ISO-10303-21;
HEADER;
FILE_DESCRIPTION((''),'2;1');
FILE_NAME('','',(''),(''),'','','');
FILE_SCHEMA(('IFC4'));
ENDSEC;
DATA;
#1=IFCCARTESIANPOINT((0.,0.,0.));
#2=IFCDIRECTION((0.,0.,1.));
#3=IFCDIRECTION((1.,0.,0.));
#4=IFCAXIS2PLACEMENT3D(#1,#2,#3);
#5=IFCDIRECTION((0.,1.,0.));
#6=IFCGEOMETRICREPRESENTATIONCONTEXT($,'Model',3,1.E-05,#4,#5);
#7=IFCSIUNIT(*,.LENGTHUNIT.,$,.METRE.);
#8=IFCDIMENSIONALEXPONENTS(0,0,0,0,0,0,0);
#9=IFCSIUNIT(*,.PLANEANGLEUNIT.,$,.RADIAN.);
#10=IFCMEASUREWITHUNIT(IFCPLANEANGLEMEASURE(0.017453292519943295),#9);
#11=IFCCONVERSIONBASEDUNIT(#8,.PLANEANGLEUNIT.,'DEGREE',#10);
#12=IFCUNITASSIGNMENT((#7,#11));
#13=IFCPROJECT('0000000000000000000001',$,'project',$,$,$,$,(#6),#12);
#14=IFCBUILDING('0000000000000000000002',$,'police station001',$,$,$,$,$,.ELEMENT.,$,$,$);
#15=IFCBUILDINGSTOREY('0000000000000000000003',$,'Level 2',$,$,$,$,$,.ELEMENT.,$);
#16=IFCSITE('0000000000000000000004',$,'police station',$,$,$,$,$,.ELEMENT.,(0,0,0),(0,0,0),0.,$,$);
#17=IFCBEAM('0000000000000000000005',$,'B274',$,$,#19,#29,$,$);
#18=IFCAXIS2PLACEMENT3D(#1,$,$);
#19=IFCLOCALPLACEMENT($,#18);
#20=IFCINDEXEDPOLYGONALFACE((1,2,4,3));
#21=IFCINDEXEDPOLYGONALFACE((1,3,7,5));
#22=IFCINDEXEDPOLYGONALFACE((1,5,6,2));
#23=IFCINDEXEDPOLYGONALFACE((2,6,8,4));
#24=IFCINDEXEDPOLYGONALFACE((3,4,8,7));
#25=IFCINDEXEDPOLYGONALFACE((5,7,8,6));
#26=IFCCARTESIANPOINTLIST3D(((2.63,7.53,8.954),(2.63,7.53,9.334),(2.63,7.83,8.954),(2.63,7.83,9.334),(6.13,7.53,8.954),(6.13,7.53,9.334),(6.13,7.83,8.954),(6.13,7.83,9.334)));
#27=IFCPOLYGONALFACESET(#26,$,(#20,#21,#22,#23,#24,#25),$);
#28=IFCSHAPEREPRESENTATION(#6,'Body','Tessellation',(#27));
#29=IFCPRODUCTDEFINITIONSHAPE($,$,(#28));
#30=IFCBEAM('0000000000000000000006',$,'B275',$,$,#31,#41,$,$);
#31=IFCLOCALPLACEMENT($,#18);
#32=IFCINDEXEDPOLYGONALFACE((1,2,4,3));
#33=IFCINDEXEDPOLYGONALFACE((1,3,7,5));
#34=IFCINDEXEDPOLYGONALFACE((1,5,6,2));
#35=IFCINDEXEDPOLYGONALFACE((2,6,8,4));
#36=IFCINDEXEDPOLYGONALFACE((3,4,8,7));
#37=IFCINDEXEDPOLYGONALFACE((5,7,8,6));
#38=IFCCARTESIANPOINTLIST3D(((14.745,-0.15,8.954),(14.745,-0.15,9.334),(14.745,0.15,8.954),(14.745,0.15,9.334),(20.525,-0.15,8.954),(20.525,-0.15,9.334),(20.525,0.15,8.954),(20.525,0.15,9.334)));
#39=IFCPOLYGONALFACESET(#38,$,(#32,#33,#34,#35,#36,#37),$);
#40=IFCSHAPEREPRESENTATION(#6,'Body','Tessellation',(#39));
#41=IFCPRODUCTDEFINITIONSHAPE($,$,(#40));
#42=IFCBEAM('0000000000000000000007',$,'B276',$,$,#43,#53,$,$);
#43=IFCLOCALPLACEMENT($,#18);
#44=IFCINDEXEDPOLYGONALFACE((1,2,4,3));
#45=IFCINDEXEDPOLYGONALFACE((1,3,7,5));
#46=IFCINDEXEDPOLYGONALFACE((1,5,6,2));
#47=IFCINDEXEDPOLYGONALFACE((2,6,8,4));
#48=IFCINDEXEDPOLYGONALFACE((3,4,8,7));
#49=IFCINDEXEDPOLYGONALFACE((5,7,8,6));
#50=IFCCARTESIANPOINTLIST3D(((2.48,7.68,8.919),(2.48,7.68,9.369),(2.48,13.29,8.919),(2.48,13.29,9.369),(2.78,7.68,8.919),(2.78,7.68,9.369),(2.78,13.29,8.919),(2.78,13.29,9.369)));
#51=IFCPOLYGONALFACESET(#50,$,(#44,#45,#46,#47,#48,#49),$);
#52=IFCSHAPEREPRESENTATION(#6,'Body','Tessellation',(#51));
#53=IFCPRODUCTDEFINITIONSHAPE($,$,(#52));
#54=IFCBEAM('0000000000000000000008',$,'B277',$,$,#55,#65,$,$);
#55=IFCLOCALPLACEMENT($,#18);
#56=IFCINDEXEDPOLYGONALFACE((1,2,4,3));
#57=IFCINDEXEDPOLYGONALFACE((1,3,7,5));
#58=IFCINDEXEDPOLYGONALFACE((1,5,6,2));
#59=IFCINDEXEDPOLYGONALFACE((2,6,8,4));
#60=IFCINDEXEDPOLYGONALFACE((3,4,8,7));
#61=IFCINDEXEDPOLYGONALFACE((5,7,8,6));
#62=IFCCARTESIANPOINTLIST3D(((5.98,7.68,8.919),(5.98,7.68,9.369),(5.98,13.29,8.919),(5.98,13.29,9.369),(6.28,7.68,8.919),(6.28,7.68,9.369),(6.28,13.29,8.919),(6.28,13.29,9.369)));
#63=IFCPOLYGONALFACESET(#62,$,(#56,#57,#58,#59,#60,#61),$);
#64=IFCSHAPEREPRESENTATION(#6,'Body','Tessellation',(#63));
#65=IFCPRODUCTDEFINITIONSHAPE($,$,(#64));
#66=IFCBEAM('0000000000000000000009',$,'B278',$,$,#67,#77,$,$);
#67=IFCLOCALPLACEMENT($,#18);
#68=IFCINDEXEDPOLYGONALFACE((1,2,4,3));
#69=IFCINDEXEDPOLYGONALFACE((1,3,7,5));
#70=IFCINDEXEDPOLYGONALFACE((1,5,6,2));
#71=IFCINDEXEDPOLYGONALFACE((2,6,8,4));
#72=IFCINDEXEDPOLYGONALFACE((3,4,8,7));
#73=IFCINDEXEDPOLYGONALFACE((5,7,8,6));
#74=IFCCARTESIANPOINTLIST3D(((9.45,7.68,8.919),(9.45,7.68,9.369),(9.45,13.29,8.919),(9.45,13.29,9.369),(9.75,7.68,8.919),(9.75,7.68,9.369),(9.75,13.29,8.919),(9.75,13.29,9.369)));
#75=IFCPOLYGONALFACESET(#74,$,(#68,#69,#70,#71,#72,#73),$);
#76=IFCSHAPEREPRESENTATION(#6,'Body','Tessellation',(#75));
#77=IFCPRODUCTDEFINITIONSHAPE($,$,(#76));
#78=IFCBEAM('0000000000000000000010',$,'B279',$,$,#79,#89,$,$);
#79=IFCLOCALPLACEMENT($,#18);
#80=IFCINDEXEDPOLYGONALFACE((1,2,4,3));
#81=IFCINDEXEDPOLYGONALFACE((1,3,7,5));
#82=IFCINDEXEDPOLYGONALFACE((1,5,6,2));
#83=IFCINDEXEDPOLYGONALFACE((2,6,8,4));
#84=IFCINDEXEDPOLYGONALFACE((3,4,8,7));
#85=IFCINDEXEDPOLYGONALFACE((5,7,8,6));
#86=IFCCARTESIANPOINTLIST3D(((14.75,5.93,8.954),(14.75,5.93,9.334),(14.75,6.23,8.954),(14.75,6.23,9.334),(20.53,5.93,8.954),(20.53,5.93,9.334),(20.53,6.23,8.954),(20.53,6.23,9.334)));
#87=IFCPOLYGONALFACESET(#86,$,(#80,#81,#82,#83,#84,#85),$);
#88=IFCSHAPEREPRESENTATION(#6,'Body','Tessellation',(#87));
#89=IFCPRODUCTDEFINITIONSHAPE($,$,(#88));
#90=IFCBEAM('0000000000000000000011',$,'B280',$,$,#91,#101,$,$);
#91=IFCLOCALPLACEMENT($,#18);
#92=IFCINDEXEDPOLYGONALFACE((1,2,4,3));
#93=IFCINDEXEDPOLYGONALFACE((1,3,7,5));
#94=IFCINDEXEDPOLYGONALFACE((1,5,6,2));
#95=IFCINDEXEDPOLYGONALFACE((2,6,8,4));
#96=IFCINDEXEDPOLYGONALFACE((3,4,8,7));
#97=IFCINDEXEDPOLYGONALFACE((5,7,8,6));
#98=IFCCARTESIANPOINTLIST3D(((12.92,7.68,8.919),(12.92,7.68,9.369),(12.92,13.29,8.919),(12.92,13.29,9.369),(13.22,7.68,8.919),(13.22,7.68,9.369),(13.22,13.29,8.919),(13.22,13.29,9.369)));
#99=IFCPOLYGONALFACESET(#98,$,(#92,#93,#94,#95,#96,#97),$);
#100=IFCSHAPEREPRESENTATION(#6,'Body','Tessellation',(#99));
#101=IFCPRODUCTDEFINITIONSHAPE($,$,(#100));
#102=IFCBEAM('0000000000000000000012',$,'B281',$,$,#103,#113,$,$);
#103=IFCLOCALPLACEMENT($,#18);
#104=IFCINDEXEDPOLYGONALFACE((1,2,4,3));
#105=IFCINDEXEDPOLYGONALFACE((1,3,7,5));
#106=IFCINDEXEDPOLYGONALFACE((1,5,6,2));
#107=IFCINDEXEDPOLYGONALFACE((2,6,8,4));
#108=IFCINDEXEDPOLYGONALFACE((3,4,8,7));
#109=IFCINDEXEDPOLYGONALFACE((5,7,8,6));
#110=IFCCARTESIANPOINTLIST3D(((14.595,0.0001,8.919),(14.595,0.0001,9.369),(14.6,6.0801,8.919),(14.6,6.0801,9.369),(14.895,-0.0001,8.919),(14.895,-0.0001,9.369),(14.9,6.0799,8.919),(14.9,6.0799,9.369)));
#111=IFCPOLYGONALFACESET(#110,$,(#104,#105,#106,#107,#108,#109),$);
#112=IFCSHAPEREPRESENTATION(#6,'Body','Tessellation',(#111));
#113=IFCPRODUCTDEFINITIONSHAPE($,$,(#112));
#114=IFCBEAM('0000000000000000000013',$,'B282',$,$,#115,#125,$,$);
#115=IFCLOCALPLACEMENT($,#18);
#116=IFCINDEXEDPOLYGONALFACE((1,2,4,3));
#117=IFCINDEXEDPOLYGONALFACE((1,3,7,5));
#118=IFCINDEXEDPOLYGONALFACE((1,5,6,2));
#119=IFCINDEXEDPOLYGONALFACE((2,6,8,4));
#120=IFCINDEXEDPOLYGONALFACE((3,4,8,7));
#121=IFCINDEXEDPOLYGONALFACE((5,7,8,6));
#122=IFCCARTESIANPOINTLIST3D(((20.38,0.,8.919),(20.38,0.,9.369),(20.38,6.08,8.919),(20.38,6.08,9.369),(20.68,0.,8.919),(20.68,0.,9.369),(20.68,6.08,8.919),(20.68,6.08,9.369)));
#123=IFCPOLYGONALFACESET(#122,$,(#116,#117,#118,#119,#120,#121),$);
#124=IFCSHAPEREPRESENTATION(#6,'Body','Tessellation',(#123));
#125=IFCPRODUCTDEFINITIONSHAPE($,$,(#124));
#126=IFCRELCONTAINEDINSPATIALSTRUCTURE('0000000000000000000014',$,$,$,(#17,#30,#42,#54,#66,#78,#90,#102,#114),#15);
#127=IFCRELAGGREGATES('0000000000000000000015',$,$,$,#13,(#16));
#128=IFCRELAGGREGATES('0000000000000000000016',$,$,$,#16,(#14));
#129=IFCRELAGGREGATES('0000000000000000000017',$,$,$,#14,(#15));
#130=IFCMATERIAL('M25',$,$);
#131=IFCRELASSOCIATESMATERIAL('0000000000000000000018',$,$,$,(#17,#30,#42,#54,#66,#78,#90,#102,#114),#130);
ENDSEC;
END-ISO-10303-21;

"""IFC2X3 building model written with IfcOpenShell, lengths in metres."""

from ifc_helpers import new_model, entity, si_unit, converted_unit, direction, frame, frame_2d, origin_with_axes, place, context, project, spatial, rectangle, extrude, material, element, save


model = new_model("IFC2X3")

# Units and contexts
model_context = context("Model", 3, precision=1e-05, world=origin_with_axes(), true_north=direction((0.0, 1.0, 0.0)))
ifc_project = project(units=[si_unit("LENGTHUNIT", "METRE"), converted_unit("PLANEANGLEUNIT", "DEGREE", entity("IfcPlaneAngleMeasure", 0.017453292519943295), si_unit("PLANEANGLEUNIT", "RADIAN"), dimensions=[0, 0, 0, 0, 0, 0, 0])], contexts=[model_context])

# Site, building, storey
site = spatial("IfcSite", under=ifc_project, Name="police station", CompositionType="ELEMENT", RefLatitude=(0, 0, 0), RefLongitude=(0, 0, 0), RefElevation=0.0)
building = spatial("IfcBuilding", under=site, Name="police station001", CompositionType="ELEMENT")
storey = spatial("IfcBuildingStorey", under=building, Name="Level 2", CompositionType="ELEMENT")

# Shared definitions
ifc_material = material(Name="M25")
placement = place(None, origin_with_axes())

# Beams
element("IfcBeam", 1, at=placement, inside=storey, material=ifc_material, Name="B274", context=model_context, shape_type="SweptSolid", body=[
    extrude(rectangle(XDim=0.3, YDim=0.38, at=frame_2d((0.0, 0.0), x_axis=(0.0, 1.0, 0.0))), frame((2.63, 7.68, 9.144), z_axis=(1.0, 0.0, 0.0), x_axis=(0.0, 0.0, -1.0)), (0.0, 0.0, 1.0), 3.5),
])
element("IfcBeam", 2, at=placement, inside=storey, material=ifc_material, Name="B275", context=model_context, shape_type="SweptSolid", body=[
    extrude(rectangle(XDim=0.3, YDim=0.38, at=frame_2d((0.0, 0.0), x_axis=(0.0, 1.0, 0.0))), frame((14.745, 0.0, 9.144), z_axis=(1.0, 0.0, 0.0), x_axis=(0.0, 0.0, -1.0)), (0.0, 0.0, 1.0), 5.78),
])
element("IfcBeam", 3, at=placement, inside=storey, material=ifc_material, Name="B276", context=model_context, shape_type="SweptSolid", body=[
    extrude(rectangle(XDim=0.3, YDim=0.45, at=frame_2d((0.0, 0.0), x_axis=(0.0, 1.0, 0.0))), frame((2.63, 13.29, 9.144), z_axis=(0.0, -1.0, 0.0), x_axis=(0.0, 0.0, -1.0)), (0.0, 0.0, 1.0), 5.61),
])
element("IfcBeam", 4, at=placement, inside=storey, material=ifc_material, Name="B277", context=model_context, shape_type="SweptSolid", body=[
    extrude(rectangle(XDim=0.3, YDim=0.45, at=frame_2d((0.0, 0.0), x_axis=(0.0, 1.0, 0.0))), frame((6.13, 7.68, 9.144), z_axis=(0.0, 1.0, 0.0), x_axis=(0.0, 0.0, -1.0)), (0.0, 0.0, 1.0), 5.61),
])
element("IfcBeam", 5, at=placement, inside=storey, material=ifc_material, Name="B278", context=model_context, shape_type="SweptSolid", body=[
    extrude(rectangle(XDim=0.3, YDim=0.45, at=frame_2d((0.0, 0.0), x_axis=(0.0, 1.0, 0.0))), frame((9.6, 7.68, 9.144), z_axis=(0.0, 1.0, 0.0), x_axis=(0.0, 0.0, -1.0)), (0.0, 0.0, 1.0), 5.61),
])
element("IfcBeam", 6, at=placement, inside=storey, material=ifc_material, Name="B279", context=model_context, shape_type="SweptSolid", body=[
    extrude(rectangle(XDim=0.3, YDim=0.38, at=frame_2d((0.0, 0.0), x_axis=(0.0, 1.0, 0.0))), frame((20.53, 6.08, 9.144), z_axis=(-1.0, 0.0, 0.0), x_axis=(0.0, 0.0, -1.0)), (0.0, 0.0, 1.0), 5.78),
])
element("IfcBeam", 7, at=placement, inside=storey, material=ifc_material, Name="B280", context=model_context, shape_type="SweptSolid", body=[
    extrude(rectangle(XDim=0.3, YDim=0.45, at=frame_2d((0.0, 0.0), x_axis=(0.0, 1.0, 0.0))), frame((13.07, 13.29, 9.144), z_axis=(0.0, -1.0, 0.0), x_axis=(0.0, 0.0, -1.0)), (0.0, 0.0, 1.0), 5.61),
])
element("IfcBeam", 8, at=placement, inside=storey, material=ifc_material, Name="B281", context=model_context, shape_type="SweptSolid", body=[
    extrude(rectangle(XDim=0.3, YDim=0.45, at=frame_2d((0.0, 0.0), x_axis=(0.0, 1.0, 0.0))), frame((14.745, 0.0, 9.144), z_axis=(0.000822, 1.0, 0.0), x_axis=(0.0, 0.0, -1.0)), (0.0, 0.0, 1.0), 6.08),
])
element("IfcBeam", 9, at=placement, inside=storey, material=ifc_material, Name="B282", context=model_context, shape_type="SweptSolid", body=[
    extrude(rectangle(XDim=0.3, YDim=0.45, at=frame_2d((0.0, 0.0), x_axis=(0.0, 1.0, 0.0))), frame((20.53, 0.0, 9.144), z_axis=(0.0, 1.0, 0.0), x_axis=(0.0, 0.0, -1.0)), (0.0, 0.0, 1.0), 6.08),
])

save(model, "model.ifc")
